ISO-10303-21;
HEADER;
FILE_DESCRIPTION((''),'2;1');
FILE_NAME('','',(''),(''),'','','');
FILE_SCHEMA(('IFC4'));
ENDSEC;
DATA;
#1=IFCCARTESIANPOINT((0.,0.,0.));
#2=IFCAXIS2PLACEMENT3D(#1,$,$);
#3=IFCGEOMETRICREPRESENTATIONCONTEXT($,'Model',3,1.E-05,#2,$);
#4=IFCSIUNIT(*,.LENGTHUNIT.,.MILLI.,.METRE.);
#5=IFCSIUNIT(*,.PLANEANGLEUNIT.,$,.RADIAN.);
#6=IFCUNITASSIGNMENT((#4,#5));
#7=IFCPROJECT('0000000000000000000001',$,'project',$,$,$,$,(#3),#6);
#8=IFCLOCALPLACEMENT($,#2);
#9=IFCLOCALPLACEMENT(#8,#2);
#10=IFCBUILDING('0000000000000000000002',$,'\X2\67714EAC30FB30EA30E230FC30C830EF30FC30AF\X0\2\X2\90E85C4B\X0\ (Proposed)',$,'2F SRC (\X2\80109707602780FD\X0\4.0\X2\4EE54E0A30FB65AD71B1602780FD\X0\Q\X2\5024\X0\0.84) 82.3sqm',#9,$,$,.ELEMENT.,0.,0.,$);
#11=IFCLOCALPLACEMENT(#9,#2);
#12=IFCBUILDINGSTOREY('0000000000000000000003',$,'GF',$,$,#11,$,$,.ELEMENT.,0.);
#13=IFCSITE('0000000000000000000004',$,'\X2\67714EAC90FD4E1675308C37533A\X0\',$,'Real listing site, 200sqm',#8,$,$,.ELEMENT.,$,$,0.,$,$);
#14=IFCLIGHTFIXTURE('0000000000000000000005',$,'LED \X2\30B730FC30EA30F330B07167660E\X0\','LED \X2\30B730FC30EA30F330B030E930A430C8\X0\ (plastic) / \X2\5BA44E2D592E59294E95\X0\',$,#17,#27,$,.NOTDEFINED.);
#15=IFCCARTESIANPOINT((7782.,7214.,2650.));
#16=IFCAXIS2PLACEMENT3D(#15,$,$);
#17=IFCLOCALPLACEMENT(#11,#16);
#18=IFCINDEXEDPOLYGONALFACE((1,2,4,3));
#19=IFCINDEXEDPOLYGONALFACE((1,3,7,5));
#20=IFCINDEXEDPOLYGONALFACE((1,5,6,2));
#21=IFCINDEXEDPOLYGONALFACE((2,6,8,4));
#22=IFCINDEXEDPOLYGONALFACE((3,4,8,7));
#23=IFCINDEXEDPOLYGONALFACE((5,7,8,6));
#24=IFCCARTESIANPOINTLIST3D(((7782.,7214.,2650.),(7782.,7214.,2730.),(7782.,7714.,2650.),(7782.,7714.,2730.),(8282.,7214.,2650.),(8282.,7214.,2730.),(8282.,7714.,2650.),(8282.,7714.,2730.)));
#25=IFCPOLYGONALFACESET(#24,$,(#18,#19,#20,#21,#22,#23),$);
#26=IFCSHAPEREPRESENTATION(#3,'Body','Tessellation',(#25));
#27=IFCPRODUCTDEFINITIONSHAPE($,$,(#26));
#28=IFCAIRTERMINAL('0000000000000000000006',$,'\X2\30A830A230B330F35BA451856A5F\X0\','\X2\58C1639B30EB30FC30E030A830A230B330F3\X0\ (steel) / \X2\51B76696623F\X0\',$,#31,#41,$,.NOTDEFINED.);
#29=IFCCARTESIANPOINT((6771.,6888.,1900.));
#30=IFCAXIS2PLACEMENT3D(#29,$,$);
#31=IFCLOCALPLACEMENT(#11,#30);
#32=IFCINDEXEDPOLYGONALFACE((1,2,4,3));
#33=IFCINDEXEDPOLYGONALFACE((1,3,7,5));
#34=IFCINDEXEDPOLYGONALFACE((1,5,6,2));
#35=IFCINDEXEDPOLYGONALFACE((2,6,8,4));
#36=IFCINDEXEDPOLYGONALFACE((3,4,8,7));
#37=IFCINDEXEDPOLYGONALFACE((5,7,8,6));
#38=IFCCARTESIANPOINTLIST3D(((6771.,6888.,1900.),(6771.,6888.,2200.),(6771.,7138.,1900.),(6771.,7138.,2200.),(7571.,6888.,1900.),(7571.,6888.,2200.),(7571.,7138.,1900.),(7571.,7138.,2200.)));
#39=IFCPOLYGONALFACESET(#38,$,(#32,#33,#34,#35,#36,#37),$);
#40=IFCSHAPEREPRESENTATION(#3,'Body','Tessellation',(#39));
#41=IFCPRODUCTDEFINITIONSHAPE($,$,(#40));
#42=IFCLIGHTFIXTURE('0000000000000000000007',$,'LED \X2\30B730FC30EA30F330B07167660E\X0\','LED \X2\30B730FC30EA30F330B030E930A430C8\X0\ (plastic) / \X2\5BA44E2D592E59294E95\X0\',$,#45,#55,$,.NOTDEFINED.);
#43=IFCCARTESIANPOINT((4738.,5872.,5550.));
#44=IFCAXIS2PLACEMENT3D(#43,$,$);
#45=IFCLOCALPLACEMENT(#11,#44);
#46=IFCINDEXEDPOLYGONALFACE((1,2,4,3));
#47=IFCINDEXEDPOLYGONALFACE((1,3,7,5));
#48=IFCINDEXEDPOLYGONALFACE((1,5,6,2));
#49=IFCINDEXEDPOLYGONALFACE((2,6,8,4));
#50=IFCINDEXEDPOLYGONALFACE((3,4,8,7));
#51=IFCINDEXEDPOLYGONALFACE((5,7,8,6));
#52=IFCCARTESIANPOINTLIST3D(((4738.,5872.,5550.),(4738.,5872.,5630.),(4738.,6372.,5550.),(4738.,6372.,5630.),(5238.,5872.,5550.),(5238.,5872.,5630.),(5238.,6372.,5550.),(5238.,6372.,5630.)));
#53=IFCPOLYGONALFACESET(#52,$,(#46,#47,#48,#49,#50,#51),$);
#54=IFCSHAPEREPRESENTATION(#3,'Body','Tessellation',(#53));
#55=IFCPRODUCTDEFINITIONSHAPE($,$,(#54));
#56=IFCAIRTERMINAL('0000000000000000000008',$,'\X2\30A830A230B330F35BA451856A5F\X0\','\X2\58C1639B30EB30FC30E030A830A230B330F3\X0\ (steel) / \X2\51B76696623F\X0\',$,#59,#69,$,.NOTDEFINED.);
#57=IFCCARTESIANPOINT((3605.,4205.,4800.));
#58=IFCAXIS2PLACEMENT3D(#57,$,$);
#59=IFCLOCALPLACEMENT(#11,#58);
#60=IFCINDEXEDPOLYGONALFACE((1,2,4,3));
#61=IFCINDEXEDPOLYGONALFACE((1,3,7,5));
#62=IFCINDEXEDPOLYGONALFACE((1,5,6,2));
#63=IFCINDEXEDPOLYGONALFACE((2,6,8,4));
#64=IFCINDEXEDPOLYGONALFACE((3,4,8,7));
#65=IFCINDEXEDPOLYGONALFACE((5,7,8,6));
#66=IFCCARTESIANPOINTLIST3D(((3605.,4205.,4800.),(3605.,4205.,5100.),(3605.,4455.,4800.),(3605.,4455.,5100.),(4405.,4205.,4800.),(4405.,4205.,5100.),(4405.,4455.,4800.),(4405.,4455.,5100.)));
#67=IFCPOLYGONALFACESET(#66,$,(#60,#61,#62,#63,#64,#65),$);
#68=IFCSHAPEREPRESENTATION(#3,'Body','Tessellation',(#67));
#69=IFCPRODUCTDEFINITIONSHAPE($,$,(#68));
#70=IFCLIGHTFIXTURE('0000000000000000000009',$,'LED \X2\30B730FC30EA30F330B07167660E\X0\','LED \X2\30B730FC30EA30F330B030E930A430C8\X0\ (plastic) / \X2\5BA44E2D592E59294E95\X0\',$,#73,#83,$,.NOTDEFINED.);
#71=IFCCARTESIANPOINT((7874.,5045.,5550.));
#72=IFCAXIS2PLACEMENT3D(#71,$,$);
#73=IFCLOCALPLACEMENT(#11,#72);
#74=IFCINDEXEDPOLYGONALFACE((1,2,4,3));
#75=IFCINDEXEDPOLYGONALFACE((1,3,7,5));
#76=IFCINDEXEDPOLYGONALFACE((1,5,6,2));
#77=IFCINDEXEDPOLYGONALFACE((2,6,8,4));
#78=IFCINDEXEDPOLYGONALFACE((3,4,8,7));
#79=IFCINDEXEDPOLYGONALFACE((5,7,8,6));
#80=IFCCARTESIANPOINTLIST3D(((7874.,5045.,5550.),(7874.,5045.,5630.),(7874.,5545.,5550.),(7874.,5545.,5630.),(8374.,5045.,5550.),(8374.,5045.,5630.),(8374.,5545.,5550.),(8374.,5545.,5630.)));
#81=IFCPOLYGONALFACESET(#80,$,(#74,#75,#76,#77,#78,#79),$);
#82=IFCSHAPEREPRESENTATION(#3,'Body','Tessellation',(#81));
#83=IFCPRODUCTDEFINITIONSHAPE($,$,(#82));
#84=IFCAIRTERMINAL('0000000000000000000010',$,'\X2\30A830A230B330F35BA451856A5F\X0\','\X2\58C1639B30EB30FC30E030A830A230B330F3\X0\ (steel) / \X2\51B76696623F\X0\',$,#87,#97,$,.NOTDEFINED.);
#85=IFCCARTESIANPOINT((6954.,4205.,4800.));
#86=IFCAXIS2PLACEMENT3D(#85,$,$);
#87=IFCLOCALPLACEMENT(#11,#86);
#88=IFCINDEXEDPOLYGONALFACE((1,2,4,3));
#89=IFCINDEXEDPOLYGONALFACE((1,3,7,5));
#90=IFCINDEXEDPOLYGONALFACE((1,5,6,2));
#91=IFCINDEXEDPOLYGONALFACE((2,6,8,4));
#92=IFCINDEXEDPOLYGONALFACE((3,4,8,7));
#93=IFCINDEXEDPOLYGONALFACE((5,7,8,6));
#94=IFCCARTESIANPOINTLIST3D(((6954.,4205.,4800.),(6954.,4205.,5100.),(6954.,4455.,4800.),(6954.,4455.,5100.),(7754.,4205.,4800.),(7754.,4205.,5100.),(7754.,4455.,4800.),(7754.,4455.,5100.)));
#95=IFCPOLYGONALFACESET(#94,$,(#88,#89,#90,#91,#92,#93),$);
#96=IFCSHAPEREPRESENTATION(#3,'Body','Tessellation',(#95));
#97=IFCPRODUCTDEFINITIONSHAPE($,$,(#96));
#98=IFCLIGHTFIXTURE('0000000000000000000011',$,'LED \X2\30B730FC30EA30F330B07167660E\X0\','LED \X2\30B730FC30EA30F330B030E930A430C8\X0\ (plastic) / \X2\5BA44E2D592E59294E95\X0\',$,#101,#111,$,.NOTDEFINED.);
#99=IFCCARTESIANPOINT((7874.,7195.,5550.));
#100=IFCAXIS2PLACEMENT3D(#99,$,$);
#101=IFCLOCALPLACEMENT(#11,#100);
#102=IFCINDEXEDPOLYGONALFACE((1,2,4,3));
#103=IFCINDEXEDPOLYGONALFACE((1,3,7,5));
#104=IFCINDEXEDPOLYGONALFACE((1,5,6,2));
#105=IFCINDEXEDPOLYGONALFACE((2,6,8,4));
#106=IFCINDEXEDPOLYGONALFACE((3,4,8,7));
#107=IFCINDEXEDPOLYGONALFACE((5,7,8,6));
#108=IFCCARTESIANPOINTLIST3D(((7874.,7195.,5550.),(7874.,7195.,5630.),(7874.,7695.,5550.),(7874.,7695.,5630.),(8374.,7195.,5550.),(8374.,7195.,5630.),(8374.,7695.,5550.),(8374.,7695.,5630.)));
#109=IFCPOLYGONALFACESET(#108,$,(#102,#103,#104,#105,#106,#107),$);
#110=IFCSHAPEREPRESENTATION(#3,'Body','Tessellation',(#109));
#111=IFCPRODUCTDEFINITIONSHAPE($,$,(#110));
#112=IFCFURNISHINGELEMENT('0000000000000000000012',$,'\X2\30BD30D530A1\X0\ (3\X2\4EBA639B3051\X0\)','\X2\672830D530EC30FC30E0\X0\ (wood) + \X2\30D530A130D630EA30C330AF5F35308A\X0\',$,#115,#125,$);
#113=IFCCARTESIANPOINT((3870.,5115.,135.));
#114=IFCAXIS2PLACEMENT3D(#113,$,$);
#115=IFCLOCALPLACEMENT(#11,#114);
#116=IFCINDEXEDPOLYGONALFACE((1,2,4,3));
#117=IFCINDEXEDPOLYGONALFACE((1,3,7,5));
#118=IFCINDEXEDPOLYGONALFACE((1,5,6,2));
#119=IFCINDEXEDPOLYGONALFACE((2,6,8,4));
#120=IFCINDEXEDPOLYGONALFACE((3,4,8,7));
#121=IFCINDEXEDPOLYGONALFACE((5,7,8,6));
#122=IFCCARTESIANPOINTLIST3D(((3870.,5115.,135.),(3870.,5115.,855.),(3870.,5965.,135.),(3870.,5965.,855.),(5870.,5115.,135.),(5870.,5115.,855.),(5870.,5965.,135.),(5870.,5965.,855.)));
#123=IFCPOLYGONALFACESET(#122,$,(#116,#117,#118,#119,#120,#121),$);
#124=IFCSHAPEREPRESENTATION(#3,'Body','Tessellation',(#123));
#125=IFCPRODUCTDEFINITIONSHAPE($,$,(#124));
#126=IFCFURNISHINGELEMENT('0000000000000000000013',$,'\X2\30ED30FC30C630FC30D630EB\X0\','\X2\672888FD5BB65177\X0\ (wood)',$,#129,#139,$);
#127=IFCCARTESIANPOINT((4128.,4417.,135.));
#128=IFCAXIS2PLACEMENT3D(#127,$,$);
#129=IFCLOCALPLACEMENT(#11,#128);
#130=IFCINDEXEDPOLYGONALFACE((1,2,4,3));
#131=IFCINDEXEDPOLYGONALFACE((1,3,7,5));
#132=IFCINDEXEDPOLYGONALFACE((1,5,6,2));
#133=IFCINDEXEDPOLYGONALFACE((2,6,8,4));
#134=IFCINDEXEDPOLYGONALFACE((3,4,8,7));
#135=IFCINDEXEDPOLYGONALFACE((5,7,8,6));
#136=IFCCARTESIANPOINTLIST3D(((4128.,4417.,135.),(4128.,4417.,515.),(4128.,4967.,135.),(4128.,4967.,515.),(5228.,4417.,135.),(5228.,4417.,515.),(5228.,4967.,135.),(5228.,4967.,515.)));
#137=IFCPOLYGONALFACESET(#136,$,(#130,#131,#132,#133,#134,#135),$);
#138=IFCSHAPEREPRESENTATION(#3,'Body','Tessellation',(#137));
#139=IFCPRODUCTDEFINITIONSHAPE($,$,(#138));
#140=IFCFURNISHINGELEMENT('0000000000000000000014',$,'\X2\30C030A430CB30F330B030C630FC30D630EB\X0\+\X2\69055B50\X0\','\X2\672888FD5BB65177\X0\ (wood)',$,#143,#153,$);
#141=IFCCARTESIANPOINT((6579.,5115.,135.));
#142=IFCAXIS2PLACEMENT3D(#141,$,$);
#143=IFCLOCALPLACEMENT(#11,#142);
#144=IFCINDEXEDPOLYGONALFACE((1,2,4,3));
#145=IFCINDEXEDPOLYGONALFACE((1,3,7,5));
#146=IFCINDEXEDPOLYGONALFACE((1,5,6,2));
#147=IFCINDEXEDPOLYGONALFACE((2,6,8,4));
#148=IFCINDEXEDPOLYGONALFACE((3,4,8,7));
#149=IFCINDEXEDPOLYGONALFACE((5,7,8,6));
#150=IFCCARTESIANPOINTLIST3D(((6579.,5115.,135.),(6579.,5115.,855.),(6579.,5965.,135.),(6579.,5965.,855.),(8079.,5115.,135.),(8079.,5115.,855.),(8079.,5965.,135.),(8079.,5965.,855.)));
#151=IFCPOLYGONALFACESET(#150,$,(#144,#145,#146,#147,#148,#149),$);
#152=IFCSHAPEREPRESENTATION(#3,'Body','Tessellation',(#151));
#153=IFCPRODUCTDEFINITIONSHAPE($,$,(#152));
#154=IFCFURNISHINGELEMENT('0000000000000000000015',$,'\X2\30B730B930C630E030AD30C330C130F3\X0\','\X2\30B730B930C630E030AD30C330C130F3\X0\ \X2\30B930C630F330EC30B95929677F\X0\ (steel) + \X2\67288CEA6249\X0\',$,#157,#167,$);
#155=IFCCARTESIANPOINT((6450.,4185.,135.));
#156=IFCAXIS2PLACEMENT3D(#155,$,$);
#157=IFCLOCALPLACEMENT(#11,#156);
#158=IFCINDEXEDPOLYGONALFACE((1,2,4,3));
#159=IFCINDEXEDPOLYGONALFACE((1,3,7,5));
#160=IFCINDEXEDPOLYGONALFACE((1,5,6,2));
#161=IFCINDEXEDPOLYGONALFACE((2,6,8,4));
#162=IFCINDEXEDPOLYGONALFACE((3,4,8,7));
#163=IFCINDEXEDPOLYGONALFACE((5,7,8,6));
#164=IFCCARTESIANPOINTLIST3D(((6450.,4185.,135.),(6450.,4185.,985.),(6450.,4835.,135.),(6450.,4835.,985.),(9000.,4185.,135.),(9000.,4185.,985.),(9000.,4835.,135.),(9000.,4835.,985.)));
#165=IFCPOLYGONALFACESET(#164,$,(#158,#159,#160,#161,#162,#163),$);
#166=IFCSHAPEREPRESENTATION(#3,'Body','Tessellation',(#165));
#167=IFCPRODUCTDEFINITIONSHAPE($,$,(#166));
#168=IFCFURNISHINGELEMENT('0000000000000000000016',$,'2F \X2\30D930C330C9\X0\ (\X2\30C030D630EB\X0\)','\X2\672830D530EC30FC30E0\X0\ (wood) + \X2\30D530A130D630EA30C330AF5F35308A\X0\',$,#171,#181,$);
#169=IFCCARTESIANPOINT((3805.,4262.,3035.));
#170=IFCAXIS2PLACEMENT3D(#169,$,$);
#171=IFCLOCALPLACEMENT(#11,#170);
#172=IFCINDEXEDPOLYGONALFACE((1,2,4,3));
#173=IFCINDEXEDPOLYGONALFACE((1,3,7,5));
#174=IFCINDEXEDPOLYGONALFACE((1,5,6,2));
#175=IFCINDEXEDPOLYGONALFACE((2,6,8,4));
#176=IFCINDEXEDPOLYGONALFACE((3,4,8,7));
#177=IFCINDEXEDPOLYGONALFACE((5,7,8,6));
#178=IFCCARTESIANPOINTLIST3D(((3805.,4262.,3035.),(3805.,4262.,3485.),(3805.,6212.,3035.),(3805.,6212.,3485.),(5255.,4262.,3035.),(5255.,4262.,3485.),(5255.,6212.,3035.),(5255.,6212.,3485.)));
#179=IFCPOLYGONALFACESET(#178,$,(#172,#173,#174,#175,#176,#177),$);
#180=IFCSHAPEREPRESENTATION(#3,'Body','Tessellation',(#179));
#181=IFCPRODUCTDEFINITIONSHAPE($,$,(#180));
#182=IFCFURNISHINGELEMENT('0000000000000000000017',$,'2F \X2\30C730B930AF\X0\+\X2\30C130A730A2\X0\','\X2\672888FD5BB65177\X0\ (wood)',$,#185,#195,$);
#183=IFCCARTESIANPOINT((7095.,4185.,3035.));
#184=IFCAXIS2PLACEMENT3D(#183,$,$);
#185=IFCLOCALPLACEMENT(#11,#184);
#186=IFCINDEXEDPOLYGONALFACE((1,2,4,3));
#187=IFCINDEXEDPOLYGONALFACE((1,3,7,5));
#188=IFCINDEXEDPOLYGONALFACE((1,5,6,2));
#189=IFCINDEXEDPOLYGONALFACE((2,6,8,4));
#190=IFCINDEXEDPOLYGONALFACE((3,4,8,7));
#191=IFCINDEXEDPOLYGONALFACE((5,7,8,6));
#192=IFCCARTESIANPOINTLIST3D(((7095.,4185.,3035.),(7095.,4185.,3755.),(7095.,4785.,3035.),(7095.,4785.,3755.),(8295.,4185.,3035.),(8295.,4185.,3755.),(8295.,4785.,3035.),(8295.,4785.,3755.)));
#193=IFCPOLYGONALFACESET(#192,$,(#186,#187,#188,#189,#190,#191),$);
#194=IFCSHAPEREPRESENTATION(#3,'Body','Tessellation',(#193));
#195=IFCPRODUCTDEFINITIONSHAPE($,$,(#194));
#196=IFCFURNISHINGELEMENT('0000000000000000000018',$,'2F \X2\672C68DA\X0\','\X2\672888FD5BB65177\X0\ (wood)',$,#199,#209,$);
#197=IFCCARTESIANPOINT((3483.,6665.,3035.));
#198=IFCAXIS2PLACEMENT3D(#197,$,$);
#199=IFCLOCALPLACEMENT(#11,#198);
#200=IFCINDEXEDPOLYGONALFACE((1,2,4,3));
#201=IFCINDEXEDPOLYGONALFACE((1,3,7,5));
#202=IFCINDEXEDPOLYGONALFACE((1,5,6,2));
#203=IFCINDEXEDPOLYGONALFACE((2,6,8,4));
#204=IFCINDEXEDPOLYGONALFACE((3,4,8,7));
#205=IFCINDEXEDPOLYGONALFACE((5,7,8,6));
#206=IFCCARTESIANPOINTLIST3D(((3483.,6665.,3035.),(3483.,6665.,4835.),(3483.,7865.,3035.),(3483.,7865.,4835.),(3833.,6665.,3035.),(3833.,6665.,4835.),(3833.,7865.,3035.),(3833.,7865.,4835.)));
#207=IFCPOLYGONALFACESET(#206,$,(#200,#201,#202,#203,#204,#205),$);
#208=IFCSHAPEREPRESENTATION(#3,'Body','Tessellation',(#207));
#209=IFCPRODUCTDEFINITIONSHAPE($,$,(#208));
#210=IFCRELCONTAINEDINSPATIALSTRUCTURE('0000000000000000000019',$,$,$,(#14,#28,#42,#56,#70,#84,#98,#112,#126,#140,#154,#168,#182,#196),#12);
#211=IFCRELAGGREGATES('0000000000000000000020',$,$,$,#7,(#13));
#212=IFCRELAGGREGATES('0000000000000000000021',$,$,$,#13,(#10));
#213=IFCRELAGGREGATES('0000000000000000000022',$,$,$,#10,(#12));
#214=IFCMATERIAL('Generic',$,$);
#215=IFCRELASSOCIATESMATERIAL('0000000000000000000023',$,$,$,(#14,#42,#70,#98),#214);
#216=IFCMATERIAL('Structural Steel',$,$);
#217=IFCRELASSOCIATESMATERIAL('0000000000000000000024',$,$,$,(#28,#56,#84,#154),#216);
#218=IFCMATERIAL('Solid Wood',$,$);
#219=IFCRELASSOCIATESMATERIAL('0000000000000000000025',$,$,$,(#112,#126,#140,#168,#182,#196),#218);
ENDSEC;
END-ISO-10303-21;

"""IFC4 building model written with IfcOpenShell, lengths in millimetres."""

from ifc_helpers import new_model, si_unit, frame, frame_2d, origin, place, context, project, spatial, rectangle, extrude, material, element, save


model = new_model("IFC4")

# Units and contexts
model_context = context("Model", 3, precision=1e-05, world=origin())
ifc_project = project(units=[si_unit("LENGTHUNIT", "METRE", prefix="MILLI"), si_unit("PLANEANGLEUNIT", "RADIAN")], contexts=[model_context])

# Site, building, storey
site_placement = place(None, origin())
site = spatial("IfcSite", under=ifc_project, at=site_placement, Name="東京都世田谷区", ObjectType="Real listing site, 200sqm", CompositionType="ELEMENT", RefElevation=0.0)
building_placement = place(site_placement, origin())
building = spatial("IfcBuilding", under=site, at=building_placement, Name="東京・リモートワーク2部屋 (Proposed)", ObjectType="2F SRC (耐震性能4.0以上・断熱性能Q値0.84) 82.3sqm", CompositionType="ELEMENT", ElevationOfRefHeight=0.0, ElevationOfTerrain=0.0)
storey_placement = place(building_placement, origin())
storey = spatial("IfcBuildingStorey", under=building, at=storey_placement, Name="GF", CompositionType="ELEMENT", Elevation=0.0)

# Shared definitions
ifc_material_1 = material(Name="Solid Wood")

# Shared definitions
ifc_material_2 = material(Name="Structural Steel")

# Shared definitions
ifc_material_3 = material(Name="Generic")

# Light fixture
light_fixture_1_placement = place(storey_placement, frame((7782.0, 7214.0, 2650.0)))
element("IfcLightFixture", 1, at=light_fixture_1_placement, inside=storey, material=ifc_material_3, Name="LED シーリング照明", Description="LED シーリングライト (plastic) / 室中央天井", PredefinedType="NOTDEFINED", context=model_context, shape_type="SweptSolid", body=[
    extrude(rectangle(XDim=500.0, YDim=500.0, at=frame_2d((250.0, 250.0))), frame((7782.0, 7214.0, 2650.0)), (0.0, 0.0, 1.0), 80.0),
])

# Air terminal
air_terminal_1_placement = place(storey_placement, frame((6771.0, 6888.0, 1900.0)))
element("IfcAirTerminal", 2, at=air_terminal_1_placement, inside=storey, material=ifc_material_2, Name="エアコン室内機", Description="壁掛ルームエアコン (steel) / 冷暖房", PredefinedType="NOTDEFINED", context=model_context, shape_type="SweptSolid", body=[
    extrude(rectangle(XDim=800.0, YDim=250.0, at=frame_2d((400.0, 125.0))), frame((6771.0, 6888.0, 1900.0)), (0.0, 0.0, 1.0), 300.0),
])

# Light fixture
light_fixture_2_placement = place(storey_placement, frame((4738.0, 5872.0, 5550.0)))
element("IfcLightFixture", 3, at=light_fixture_2_placement, inside=storey, material=ifc_material_3, Name="LED シーリング照明", Description="LED シーリングライト (plastic) / 室中央天井", PredefinedType="NOTDEFINED", context=model_context, shape_type="SweptSolid", body=[
    extrude(rectangle(XDim=500.0, YDim=500.0, at=frame_2d((250.0, 250.0))), frame((4738.0, 5872.0, 5550.0)), (0.0, 0.0, 1.0), 80.0),
])

# Air terminal
air_terminal_2_placement = place(storey_placement, frame((3605.0, 4205.0, 4800.0)))
element("IfcAirTerminal", 4, at=air_terminal_2_placement, inside=storey, material=ifc_material_2, Name="エアコン室内機", Description="壁掛ルームエアコン (steel) / 冷暖房", PredefinedType="NOTDEFINED", context=model_context, shape_type="SweptSolid", body=[
    extrude(rectangle(XDim=800.0, YDim=250.0, at=frame_2d((400.0, 125.0))), frame((3605.0, 4205.0, 4800.0)), (0.0, 0.0, 1.0), 300.0),
])

# Light fixture
light_fixture_3_placement = place(storey_placement, frame((7874.0, 5045.0, 5550.0)))
element("IfcLightFixture", 5, at=light_fixture_3_placement, inside=storey, material=ifc_material_3, Name="LED シーリング照明", Description="LED シーリングライト (plastic) / 室中央天井", PredefinedType="NOTDEFINED", context=model_context, shape_type="SweptSolid", body=[
    extrude(rectangle(XDim=500.0, YDim=500.0, at=frame_2d((250.0, 250.0))), frame((7874.0, 5045.0, 5550.0)), (0.0, 0.0, 1.0), 80.0),
])

# Air terminal
air_terminal_3_placement = place(storey_placement, frame((6954.0, 4205.0, 4800.0)))
element("IfcAirTerminal", 6, at=air_terminal_3_placement, inside=storey, material=ifc_material_2, Name="エアコン室内機", Description="壁掛ルームエアコン (steel) / 冷暖房", PredefinedType="NOTDEFINED", context=model_context, shape_type="SweptSolid", body=[
    extrude(rectangle(XDim=800.0, YDim=250.0, at=frame_2d((400.0, 125.0))), frame((6954.0, 4205.0, 4800.0)), (0.0, 0.0, 1.0), 300.0),
])

# Light fixture
light_fixture_4_placement = place(storey_placement, frame((7874.0, 7195.0, 5550.0)))
element("IfcLightFixture", 7, at=light_fixture_4_placement, inside=storey, material=ifc_material_3, Name="LED シーリング照明", Description="LED シーリングライト (plastic) / 室中央天井", PredefinedType="NOTDEFINED", context=model_context, shape_type="SweptSolid", body=[
    extrude(rectangle(XDim=500.0, YDim=500.0, at=frame_2d((250.0, 250.0))), frame((7874.0, 7195.0, 5550.0)), (0.0, 0.0, 1.0), 80.0),
])

# Furnishing elements
furnishing_1_placement = place(storey_placement, frame((3870.0, 5115.0, 135.0)))
element("IfcFurnishingElement", 8, at=furnishing_1_placement, inside=storey, material=ifc_material_1, Name="ソファ (3人掛け)", Description="木フレーム (wood) + ファブリック張り", context=model_context, shape_type="SweptSolid", body=[
    extrude(rectangle(XDim=2000.0, YDim=850.0, at=frame_2d((1000.0, 425.0))), frame((3870.0, 5115.0, 135.0)), (0.0, 0.0, 1.0), 720.0),
])
furnishing_2_placement = place(storey_placement, frame((4128.0, 4417.0, 135.0)))
element("IfcFurnishingElement", 9, at=furnishing_2_placement, inside=storey, material=ifc_material_1, Name="ローテーブル", Description="木製家具 (wood)", context=model_context, shape_type="SweptSolid", body=[
    extrude(rectangle(XDim=1100.0, YDim=550.0, at=frame_2d((550.0, 275.0))), frame((4128.0, 4417.0, 135.0)), (0.0, 0.0, 1.0), 380.0),
])
furnishing_3_placement = place(storey_placement, frame((6579.0, 5115.0, 135.0)))
element("IfcFurnishingElement", 10, at=furnishing_3_placement, inside=storey, material=ifc_material_1, Name="ダイニングテーブル+椅子", Description="木製家具 (wood)", context=model_context, shape_type="SweptSolid", body=[
    extrude(rectangle(XDim=1500.0, YDim=850.0, at=frame_2d((750.0, 425.0))), frame((6579.0, 5115.0, 135.0)), (0.0, 0.0, 1.0), 720.0),
])
furnishing_4_placement = place(storey_placement, frame((6450.0, 4185.0, 135.0)))
element("IfcFurnishingElement", 11, at=furnishing_4_placement, inside=storey, material=ifc_material_2, Name="システムキッチン", Description="システムキッチン ステンレス天板 (steel) + 木質扉", context=model_context, shape_type="SweptSolid", body=[
    extrude(rectangle(XDim=2550.0, YDim=650.0, at=frame_2d((1275.0, 325.0))), frame((6450.0, 4185.0, 135.0)), (0.0, 0.0, 1.0), 850.0),
])
furnishing_5_placement = place(storey_placement, frame((3805.0, 4262.0, 3035.0)))
element("IfcFurnishingElement", 12, at=furnishing_5_placement, inside=storey, material=ifc_material_1, Name="2F ベッド (ダブル)", Description="木フレーム (wood) + ファブリック張り", context=model_context, shape_type="SweptSolid", body=[
    extrude(rectangle(XDim=1450.0, YDim=1950.0, at=frame_2d((725.0, 975.0))), frame((3805.0, 4262.0, 3035.0)), (0.0, 0.0, 1.0), 450.0),
])
furnishing_6_placement = place(storey_placement, frame((7095.0, 4185.0, 3035.0)))
element("IfcFurnishingElement", 13, at=furnishing_6_placement, inside=storey, material=ifc_material_1, Name="2F デスク+チェア", Description="木製家具 (wood)", context=model_context, shape_type="SweptSolid", body=[
    extrude(rectangle(XDim=1200.0, YDim=600.0, at=frame_2d((600.0, 300.0))), frame((7095.0, 4185.0, 3035.0)), (0.0, 0.0, 1.0), 720.0),
])
furnishing_7_placement = place(storey_placement, frame((3483.0, 6665.0, 3035.0)))
element("IfcFurnishingElement", 14, at=furnishing_7_placement, inside=storey, material=ifc_material_1, Name="2F 本棚", Description="木製家具 (wood)", context=model_context, shape_type="SweptSolid", body=[
    extrude(rectangle(XDim=350.0, YDim=1200.0, at=frame_2d((175.0, 600.0))), frame((3483.0, 6665.0, 3035.0)), (0.0, 0.0, 1.0), 1800.0),
])

save(model, "model.ifc")
